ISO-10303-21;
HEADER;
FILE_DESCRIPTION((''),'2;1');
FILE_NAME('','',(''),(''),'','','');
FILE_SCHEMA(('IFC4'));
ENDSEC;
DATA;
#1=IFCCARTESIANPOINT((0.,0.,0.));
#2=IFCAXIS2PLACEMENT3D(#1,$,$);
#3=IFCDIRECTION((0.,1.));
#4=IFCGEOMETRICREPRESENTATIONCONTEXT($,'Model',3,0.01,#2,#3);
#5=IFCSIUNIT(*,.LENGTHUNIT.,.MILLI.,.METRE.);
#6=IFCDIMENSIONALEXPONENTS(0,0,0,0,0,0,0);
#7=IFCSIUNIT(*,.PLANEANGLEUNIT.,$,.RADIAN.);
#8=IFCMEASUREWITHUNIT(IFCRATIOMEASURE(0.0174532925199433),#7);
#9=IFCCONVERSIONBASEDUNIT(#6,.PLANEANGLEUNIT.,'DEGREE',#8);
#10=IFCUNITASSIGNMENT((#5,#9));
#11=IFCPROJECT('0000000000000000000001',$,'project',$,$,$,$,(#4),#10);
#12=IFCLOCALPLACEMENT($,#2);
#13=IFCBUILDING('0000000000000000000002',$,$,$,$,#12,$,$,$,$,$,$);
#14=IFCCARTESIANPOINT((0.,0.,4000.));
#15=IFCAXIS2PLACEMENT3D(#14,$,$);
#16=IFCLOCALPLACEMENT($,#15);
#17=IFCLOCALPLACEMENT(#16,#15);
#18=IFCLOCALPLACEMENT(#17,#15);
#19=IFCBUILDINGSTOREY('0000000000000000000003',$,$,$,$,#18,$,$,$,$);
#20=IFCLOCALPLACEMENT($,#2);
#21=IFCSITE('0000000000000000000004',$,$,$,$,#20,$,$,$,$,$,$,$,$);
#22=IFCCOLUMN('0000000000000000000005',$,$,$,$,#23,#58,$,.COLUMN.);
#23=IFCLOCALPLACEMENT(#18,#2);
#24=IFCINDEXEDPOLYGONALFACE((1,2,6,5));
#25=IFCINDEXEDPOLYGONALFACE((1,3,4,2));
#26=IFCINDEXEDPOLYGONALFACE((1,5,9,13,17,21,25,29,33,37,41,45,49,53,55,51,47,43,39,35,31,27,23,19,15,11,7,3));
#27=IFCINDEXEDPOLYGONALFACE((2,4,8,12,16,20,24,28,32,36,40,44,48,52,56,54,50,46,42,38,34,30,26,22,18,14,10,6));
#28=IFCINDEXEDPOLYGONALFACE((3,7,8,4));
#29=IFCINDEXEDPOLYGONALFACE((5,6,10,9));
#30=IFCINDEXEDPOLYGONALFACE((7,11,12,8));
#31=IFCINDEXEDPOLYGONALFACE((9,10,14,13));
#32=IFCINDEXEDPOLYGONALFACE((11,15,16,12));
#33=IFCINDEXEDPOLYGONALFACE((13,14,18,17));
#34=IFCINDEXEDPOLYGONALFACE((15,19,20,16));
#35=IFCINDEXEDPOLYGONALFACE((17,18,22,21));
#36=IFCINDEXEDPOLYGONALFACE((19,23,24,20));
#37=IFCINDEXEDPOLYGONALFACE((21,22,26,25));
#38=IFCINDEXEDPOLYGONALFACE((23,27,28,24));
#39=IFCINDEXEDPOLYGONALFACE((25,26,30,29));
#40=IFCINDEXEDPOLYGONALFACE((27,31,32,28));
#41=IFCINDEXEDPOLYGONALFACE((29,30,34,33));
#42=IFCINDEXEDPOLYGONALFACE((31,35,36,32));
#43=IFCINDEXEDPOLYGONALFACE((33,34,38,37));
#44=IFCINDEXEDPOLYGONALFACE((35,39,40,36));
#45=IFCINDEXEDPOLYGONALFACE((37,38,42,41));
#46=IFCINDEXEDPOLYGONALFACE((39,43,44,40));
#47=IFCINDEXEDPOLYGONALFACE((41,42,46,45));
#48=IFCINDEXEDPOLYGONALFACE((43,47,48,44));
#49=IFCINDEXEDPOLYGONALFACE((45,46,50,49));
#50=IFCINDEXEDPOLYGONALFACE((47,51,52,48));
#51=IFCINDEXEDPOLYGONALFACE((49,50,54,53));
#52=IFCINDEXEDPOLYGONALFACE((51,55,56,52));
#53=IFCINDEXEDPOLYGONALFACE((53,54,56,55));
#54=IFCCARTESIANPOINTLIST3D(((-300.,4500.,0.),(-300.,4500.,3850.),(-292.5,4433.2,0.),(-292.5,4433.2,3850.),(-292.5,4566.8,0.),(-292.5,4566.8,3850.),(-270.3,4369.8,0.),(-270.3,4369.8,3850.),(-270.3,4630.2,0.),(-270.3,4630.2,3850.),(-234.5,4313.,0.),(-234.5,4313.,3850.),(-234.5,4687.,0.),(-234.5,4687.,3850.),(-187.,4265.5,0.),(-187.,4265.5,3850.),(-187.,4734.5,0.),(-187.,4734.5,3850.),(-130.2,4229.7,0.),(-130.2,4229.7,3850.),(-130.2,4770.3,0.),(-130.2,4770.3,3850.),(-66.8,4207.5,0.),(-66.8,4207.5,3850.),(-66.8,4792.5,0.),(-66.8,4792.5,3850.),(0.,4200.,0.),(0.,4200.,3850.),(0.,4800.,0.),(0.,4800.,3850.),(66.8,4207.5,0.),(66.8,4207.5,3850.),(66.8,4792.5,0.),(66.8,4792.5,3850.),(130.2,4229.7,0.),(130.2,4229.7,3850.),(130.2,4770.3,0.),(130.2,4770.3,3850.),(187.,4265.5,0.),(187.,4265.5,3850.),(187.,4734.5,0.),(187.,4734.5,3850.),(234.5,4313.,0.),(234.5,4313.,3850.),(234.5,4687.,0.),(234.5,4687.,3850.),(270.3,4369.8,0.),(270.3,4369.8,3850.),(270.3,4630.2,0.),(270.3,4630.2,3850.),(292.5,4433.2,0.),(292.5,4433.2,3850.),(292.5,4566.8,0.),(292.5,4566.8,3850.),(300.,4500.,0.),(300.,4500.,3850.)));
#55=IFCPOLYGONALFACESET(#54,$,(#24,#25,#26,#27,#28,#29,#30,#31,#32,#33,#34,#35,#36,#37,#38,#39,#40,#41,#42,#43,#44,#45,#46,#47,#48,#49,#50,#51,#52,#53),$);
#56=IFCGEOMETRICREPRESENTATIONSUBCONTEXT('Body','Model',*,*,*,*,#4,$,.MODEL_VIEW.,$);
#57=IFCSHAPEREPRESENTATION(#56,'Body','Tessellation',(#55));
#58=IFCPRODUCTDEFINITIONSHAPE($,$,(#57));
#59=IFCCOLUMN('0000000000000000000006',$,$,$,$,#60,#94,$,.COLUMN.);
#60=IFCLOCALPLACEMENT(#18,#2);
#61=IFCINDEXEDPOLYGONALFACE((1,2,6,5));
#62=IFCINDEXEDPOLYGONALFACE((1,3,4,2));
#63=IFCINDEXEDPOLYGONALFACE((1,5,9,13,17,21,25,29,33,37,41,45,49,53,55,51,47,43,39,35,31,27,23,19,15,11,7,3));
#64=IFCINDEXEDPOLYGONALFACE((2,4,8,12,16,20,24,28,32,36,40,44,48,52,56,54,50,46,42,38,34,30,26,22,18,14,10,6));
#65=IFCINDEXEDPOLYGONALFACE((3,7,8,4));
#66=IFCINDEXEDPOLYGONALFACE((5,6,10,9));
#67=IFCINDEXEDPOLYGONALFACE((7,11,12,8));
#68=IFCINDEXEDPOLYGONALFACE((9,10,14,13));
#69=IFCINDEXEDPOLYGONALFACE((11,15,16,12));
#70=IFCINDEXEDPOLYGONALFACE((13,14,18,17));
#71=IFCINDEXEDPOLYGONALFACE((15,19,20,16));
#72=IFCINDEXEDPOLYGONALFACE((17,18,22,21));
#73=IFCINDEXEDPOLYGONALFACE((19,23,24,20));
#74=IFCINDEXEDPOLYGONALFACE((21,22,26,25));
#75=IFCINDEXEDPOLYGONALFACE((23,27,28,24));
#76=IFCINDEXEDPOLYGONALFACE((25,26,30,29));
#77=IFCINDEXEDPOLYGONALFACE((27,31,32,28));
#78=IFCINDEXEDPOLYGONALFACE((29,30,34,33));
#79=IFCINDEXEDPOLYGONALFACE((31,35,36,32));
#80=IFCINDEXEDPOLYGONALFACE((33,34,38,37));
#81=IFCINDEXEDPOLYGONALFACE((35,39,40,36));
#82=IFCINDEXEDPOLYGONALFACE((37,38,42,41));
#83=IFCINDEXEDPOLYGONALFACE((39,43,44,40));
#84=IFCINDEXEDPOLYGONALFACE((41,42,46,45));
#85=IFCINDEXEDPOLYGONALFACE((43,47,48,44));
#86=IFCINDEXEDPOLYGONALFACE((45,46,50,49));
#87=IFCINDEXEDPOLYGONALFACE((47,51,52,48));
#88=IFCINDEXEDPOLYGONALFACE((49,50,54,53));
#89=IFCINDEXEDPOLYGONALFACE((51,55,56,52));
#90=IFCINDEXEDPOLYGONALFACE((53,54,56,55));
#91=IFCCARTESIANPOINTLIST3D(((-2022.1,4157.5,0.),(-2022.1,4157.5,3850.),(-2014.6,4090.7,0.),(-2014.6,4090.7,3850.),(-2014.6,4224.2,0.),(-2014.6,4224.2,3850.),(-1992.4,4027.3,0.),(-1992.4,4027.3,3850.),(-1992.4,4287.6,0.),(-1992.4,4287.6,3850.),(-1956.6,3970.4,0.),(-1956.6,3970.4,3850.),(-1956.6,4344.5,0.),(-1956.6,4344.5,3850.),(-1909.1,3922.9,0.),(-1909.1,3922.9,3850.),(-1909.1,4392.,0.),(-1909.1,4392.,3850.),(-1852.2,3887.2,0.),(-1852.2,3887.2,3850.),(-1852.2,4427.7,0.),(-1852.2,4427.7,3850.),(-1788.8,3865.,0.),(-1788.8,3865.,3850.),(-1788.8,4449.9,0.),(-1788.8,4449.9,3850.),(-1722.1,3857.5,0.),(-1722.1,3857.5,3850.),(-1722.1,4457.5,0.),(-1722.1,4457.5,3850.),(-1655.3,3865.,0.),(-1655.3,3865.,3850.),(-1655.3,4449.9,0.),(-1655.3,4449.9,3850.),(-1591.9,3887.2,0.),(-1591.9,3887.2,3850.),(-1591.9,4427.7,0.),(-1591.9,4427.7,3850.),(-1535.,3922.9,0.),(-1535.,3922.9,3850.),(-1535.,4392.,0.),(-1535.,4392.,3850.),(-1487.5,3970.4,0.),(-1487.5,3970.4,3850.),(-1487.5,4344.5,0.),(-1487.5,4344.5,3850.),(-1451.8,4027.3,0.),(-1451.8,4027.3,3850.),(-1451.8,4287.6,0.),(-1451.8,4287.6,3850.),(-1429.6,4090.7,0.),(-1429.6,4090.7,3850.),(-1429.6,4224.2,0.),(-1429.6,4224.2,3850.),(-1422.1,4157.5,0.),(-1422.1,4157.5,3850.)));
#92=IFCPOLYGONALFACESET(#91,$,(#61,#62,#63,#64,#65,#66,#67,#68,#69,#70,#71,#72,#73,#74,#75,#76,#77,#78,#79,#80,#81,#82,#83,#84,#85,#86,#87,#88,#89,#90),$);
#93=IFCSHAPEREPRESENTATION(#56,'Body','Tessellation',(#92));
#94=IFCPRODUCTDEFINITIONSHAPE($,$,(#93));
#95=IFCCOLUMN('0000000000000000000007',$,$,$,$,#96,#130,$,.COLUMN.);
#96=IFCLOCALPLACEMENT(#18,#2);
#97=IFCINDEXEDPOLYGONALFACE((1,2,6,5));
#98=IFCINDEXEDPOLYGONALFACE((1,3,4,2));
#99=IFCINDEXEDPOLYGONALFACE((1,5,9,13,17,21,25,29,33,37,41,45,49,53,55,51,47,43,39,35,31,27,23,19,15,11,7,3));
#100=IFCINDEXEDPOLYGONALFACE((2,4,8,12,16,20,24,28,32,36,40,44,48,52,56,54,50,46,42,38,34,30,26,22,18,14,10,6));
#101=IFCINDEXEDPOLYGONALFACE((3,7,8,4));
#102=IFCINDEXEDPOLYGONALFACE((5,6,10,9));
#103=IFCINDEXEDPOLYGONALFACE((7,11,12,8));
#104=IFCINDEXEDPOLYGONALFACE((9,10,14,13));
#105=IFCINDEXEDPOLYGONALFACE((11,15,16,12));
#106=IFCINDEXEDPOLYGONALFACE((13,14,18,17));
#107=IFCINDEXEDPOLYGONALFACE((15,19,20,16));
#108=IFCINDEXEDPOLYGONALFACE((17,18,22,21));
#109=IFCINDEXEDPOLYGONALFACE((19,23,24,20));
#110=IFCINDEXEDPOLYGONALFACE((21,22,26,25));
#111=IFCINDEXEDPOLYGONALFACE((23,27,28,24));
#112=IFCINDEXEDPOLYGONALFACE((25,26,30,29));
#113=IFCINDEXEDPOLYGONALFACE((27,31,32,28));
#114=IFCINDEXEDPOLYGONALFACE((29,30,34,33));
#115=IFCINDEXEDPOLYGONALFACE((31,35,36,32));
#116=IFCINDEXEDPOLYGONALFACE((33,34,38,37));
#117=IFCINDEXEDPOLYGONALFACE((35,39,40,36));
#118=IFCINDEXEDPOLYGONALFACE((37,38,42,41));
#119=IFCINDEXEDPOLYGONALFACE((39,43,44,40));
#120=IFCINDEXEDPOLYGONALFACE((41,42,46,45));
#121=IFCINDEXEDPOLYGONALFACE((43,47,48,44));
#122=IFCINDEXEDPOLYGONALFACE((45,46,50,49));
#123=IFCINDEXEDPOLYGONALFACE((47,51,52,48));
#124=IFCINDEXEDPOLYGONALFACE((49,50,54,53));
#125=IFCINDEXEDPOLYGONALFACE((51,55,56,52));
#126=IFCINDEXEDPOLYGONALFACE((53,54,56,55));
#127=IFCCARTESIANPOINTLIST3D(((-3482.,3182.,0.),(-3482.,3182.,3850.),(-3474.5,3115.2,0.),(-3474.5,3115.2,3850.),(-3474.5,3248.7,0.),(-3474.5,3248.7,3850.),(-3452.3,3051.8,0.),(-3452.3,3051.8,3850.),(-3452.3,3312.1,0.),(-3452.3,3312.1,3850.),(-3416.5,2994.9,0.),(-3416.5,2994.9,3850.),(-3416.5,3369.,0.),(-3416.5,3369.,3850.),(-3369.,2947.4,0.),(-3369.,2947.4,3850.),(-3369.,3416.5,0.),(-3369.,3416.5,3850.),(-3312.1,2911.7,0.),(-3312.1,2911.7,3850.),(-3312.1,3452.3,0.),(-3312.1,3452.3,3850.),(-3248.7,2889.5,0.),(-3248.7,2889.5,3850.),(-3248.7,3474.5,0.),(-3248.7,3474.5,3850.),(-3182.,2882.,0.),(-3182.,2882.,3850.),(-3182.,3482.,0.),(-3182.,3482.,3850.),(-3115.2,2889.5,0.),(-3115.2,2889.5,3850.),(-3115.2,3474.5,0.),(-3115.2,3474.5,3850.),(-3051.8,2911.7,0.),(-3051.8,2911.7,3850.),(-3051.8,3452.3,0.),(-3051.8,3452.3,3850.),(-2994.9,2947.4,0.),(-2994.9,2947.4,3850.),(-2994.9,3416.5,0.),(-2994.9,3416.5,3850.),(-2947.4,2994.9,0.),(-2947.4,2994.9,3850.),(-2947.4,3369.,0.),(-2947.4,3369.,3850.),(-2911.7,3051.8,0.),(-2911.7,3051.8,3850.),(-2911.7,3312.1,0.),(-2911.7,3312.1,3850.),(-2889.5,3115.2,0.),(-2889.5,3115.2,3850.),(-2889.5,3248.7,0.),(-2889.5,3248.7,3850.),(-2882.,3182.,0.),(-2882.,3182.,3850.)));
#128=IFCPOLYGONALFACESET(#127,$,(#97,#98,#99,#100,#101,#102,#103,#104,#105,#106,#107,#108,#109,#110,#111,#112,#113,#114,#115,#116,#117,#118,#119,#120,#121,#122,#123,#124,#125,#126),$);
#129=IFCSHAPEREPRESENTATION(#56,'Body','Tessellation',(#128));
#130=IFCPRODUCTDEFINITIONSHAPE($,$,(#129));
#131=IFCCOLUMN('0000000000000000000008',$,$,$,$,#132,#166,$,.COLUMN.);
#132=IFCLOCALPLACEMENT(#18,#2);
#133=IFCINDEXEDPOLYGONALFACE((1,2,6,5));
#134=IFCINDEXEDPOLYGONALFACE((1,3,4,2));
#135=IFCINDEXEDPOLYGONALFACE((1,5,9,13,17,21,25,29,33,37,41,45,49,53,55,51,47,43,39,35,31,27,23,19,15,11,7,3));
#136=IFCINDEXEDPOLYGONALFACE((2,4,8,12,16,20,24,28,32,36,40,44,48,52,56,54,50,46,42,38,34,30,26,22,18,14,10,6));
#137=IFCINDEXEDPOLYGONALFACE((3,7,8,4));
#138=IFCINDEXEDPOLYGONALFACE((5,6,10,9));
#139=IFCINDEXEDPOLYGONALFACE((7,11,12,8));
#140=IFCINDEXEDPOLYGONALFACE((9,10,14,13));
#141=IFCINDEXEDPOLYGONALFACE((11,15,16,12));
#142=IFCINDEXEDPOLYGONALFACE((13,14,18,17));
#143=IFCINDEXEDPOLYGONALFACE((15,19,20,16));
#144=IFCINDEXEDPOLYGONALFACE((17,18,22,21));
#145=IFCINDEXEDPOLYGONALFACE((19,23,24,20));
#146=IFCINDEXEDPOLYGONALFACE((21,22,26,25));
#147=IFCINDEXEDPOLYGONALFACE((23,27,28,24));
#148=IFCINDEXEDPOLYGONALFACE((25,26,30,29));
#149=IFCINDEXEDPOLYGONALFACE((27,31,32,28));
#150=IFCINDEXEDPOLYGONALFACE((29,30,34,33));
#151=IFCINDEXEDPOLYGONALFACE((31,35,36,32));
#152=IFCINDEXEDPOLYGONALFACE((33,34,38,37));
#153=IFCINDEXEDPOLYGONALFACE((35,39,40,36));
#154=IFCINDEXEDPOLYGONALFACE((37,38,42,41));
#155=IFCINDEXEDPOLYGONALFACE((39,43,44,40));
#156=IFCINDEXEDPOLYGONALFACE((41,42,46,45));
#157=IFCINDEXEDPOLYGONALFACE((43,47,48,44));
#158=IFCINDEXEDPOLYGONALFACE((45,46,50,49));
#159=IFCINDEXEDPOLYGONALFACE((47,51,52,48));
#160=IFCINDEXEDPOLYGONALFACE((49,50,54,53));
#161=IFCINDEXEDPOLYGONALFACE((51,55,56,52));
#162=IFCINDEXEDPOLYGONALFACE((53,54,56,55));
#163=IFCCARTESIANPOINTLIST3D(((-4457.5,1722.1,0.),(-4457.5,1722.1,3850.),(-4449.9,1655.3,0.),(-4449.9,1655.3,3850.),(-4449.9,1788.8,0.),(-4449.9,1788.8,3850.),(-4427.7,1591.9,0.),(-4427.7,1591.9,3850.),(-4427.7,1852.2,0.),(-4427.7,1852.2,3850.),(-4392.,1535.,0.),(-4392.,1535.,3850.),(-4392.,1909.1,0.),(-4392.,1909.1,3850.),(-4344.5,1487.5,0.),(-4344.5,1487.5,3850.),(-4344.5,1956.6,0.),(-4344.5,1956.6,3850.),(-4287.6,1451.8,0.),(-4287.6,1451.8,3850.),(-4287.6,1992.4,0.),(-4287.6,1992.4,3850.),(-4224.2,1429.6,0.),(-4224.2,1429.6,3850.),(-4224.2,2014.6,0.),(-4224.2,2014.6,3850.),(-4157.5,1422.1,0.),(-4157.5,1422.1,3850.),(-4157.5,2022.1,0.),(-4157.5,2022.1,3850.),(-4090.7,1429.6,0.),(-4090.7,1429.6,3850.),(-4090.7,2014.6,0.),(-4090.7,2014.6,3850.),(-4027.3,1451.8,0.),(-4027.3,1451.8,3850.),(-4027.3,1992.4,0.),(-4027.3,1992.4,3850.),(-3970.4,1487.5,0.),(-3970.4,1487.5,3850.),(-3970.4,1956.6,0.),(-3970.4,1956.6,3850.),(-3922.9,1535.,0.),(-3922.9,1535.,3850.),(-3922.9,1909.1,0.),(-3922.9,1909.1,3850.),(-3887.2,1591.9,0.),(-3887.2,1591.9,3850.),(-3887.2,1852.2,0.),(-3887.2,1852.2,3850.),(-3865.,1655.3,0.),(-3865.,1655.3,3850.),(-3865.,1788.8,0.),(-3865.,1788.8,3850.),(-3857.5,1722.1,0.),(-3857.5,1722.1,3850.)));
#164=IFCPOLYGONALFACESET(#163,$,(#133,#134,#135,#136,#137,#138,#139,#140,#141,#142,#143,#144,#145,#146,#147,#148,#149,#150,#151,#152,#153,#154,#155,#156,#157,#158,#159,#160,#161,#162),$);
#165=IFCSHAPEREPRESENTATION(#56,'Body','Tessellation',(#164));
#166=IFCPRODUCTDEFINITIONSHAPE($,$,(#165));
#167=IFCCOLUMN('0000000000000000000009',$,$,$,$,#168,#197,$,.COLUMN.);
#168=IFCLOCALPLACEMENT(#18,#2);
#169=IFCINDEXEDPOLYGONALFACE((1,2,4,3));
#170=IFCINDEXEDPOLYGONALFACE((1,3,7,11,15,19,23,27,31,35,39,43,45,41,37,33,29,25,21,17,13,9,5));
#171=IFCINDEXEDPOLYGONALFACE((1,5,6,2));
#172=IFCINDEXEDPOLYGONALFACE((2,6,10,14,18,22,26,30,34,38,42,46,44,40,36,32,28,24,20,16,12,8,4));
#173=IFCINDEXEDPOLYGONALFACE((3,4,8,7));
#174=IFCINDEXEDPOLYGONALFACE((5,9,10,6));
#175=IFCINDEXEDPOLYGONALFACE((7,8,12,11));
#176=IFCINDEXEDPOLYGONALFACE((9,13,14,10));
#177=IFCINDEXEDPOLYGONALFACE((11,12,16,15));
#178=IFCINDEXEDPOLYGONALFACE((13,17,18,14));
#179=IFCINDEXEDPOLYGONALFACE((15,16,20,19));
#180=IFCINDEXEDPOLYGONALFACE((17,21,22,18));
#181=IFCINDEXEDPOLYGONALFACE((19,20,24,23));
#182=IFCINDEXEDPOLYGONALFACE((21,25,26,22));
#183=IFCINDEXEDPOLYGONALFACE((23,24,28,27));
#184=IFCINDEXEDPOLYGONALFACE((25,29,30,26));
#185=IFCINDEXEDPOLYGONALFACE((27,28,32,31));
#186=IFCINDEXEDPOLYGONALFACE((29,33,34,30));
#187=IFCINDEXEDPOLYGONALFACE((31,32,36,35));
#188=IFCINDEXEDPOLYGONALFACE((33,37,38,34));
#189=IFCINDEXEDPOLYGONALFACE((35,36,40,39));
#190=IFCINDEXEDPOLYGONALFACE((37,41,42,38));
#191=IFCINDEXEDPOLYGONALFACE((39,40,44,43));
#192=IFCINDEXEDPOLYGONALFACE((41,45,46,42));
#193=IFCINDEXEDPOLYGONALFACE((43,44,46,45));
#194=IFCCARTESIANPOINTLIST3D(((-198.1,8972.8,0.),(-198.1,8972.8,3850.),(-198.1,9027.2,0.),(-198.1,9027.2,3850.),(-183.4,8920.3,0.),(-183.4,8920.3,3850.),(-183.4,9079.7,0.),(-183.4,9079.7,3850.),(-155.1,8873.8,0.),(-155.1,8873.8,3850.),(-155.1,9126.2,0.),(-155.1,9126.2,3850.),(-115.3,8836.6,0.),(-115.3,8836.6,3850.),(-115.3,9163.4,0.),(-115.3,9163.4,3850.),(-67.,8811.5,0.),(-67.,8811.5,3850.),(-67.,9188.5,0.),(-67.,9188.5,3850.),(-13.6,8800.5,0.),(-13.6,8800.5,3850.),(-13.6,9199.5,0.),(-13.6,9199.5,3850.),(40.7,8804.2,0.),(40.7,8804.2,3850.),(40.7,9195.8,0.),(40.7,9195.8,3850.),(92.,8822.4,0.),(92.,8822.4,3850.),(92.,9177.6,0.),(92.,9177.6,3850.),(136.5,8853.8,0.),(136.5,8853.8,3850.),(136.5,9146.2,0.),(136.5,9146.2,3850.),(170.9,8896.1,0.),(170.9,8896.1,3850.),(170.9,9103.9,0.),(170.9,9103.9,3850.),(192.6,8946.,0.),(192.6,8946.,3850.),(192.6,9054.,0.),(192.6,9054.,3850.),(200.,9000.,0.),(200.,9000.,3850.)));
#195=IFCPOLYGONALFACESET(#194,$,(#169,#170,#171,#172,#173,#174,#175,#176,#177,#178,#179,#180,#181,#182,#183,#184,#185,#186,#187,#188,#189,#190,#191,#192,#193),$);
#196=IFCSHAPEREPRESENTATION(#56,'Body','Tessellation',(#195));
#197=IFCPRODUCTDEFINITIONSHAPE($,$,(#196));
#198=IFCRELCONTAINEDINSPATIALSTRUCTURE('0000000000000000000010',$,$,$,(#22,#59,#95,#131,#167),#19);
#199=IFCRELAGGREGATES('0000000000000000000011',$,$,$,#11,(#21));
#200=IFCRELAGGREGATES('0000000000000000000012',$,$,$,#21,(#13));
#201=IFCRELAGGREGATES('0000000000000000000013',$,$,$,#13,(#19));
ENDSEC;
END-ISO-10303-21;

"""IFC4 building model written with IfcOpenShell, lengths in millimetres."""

from ifc_helpers import new_model, entity, si_unit, converted_unit, direction, frame, origin, origin_2d, place, context, subcontext, project, spatial, circle, extrude, element, save


model = new_model("IFC4")

# Units and contexts
model_context = context("Model", 3, precision=0.01, world=origin(), true_north=direction((0.0, 1.0)))
body_context = subcontext(model_context, "Body", "Model", "MODEL_VIEW")
ifc_project = project(units=[si_unit("LENGTHUNIT", "METRE", prefix="MILLI"), converted_unit("PLANEANGLEUNIT", "DEGREE", entity("IfcRatioMeasure", 0.0174532925199433), si_unit("PLANEANGLEUNIT", "RADIAN"), dimensions=[0, 0, 0, 0, 0, 0, 0])], contexts=[model_context])

# Site, building, storey
site_placement = place(None, origin())
site = spatial("IfcSite", under=ifc_project, at=site_placement)
building_placement = place(None, origin())
building = spatial("IfcBuilding", under=site, at=building_placement)
placement_1 = place(None, frame((0.0, 0.0, 4000.0)))
placement_2 = place(placement_1, frame((0.0, 0.0, 4000.0)))
storey_placement = place(placement_2, frame((0.0, 0.0, 4000.0)))
storey = spatial("IfcBuildingStorey", under=building, at=storey_placement)

# Columns
for number, where in (
    (1, (0.0, 4500.0, 0.0)),
    (2, (-1722.1, 4157.5, 0.0)),
    (3, (-3182.0, 3182.0, 0.0)),
    (4, (-4157.5, 1722.1, 0.0)),
):
    element("IfcColumn", number, at=place(storey_placement, frame(where)), inside=storey, PredefinedType="COLUMN", context=body_context, shape_type="SweptSolid", body=[
        extrude(circle(Radius=300.0, at=origin_2d()), origin(), (0.0, 0.0, 1.0), 3850.0),
    ])
for number, where in (
    (5, (0.0, 9000.0, 0.0)),
):
    element("IfcColumn", number, at=place(storey_placement, frame(where)), inside=storey, PredefinedType="COLUMN", context=body_context, shape_type="SweptSolid", body=[
        extrude(circle(Radius=200.0, at=origin_2d()), origin(), (0.0, 0.0, 1.0), 3850.0),
    ])

save(model, "model.ifc")
